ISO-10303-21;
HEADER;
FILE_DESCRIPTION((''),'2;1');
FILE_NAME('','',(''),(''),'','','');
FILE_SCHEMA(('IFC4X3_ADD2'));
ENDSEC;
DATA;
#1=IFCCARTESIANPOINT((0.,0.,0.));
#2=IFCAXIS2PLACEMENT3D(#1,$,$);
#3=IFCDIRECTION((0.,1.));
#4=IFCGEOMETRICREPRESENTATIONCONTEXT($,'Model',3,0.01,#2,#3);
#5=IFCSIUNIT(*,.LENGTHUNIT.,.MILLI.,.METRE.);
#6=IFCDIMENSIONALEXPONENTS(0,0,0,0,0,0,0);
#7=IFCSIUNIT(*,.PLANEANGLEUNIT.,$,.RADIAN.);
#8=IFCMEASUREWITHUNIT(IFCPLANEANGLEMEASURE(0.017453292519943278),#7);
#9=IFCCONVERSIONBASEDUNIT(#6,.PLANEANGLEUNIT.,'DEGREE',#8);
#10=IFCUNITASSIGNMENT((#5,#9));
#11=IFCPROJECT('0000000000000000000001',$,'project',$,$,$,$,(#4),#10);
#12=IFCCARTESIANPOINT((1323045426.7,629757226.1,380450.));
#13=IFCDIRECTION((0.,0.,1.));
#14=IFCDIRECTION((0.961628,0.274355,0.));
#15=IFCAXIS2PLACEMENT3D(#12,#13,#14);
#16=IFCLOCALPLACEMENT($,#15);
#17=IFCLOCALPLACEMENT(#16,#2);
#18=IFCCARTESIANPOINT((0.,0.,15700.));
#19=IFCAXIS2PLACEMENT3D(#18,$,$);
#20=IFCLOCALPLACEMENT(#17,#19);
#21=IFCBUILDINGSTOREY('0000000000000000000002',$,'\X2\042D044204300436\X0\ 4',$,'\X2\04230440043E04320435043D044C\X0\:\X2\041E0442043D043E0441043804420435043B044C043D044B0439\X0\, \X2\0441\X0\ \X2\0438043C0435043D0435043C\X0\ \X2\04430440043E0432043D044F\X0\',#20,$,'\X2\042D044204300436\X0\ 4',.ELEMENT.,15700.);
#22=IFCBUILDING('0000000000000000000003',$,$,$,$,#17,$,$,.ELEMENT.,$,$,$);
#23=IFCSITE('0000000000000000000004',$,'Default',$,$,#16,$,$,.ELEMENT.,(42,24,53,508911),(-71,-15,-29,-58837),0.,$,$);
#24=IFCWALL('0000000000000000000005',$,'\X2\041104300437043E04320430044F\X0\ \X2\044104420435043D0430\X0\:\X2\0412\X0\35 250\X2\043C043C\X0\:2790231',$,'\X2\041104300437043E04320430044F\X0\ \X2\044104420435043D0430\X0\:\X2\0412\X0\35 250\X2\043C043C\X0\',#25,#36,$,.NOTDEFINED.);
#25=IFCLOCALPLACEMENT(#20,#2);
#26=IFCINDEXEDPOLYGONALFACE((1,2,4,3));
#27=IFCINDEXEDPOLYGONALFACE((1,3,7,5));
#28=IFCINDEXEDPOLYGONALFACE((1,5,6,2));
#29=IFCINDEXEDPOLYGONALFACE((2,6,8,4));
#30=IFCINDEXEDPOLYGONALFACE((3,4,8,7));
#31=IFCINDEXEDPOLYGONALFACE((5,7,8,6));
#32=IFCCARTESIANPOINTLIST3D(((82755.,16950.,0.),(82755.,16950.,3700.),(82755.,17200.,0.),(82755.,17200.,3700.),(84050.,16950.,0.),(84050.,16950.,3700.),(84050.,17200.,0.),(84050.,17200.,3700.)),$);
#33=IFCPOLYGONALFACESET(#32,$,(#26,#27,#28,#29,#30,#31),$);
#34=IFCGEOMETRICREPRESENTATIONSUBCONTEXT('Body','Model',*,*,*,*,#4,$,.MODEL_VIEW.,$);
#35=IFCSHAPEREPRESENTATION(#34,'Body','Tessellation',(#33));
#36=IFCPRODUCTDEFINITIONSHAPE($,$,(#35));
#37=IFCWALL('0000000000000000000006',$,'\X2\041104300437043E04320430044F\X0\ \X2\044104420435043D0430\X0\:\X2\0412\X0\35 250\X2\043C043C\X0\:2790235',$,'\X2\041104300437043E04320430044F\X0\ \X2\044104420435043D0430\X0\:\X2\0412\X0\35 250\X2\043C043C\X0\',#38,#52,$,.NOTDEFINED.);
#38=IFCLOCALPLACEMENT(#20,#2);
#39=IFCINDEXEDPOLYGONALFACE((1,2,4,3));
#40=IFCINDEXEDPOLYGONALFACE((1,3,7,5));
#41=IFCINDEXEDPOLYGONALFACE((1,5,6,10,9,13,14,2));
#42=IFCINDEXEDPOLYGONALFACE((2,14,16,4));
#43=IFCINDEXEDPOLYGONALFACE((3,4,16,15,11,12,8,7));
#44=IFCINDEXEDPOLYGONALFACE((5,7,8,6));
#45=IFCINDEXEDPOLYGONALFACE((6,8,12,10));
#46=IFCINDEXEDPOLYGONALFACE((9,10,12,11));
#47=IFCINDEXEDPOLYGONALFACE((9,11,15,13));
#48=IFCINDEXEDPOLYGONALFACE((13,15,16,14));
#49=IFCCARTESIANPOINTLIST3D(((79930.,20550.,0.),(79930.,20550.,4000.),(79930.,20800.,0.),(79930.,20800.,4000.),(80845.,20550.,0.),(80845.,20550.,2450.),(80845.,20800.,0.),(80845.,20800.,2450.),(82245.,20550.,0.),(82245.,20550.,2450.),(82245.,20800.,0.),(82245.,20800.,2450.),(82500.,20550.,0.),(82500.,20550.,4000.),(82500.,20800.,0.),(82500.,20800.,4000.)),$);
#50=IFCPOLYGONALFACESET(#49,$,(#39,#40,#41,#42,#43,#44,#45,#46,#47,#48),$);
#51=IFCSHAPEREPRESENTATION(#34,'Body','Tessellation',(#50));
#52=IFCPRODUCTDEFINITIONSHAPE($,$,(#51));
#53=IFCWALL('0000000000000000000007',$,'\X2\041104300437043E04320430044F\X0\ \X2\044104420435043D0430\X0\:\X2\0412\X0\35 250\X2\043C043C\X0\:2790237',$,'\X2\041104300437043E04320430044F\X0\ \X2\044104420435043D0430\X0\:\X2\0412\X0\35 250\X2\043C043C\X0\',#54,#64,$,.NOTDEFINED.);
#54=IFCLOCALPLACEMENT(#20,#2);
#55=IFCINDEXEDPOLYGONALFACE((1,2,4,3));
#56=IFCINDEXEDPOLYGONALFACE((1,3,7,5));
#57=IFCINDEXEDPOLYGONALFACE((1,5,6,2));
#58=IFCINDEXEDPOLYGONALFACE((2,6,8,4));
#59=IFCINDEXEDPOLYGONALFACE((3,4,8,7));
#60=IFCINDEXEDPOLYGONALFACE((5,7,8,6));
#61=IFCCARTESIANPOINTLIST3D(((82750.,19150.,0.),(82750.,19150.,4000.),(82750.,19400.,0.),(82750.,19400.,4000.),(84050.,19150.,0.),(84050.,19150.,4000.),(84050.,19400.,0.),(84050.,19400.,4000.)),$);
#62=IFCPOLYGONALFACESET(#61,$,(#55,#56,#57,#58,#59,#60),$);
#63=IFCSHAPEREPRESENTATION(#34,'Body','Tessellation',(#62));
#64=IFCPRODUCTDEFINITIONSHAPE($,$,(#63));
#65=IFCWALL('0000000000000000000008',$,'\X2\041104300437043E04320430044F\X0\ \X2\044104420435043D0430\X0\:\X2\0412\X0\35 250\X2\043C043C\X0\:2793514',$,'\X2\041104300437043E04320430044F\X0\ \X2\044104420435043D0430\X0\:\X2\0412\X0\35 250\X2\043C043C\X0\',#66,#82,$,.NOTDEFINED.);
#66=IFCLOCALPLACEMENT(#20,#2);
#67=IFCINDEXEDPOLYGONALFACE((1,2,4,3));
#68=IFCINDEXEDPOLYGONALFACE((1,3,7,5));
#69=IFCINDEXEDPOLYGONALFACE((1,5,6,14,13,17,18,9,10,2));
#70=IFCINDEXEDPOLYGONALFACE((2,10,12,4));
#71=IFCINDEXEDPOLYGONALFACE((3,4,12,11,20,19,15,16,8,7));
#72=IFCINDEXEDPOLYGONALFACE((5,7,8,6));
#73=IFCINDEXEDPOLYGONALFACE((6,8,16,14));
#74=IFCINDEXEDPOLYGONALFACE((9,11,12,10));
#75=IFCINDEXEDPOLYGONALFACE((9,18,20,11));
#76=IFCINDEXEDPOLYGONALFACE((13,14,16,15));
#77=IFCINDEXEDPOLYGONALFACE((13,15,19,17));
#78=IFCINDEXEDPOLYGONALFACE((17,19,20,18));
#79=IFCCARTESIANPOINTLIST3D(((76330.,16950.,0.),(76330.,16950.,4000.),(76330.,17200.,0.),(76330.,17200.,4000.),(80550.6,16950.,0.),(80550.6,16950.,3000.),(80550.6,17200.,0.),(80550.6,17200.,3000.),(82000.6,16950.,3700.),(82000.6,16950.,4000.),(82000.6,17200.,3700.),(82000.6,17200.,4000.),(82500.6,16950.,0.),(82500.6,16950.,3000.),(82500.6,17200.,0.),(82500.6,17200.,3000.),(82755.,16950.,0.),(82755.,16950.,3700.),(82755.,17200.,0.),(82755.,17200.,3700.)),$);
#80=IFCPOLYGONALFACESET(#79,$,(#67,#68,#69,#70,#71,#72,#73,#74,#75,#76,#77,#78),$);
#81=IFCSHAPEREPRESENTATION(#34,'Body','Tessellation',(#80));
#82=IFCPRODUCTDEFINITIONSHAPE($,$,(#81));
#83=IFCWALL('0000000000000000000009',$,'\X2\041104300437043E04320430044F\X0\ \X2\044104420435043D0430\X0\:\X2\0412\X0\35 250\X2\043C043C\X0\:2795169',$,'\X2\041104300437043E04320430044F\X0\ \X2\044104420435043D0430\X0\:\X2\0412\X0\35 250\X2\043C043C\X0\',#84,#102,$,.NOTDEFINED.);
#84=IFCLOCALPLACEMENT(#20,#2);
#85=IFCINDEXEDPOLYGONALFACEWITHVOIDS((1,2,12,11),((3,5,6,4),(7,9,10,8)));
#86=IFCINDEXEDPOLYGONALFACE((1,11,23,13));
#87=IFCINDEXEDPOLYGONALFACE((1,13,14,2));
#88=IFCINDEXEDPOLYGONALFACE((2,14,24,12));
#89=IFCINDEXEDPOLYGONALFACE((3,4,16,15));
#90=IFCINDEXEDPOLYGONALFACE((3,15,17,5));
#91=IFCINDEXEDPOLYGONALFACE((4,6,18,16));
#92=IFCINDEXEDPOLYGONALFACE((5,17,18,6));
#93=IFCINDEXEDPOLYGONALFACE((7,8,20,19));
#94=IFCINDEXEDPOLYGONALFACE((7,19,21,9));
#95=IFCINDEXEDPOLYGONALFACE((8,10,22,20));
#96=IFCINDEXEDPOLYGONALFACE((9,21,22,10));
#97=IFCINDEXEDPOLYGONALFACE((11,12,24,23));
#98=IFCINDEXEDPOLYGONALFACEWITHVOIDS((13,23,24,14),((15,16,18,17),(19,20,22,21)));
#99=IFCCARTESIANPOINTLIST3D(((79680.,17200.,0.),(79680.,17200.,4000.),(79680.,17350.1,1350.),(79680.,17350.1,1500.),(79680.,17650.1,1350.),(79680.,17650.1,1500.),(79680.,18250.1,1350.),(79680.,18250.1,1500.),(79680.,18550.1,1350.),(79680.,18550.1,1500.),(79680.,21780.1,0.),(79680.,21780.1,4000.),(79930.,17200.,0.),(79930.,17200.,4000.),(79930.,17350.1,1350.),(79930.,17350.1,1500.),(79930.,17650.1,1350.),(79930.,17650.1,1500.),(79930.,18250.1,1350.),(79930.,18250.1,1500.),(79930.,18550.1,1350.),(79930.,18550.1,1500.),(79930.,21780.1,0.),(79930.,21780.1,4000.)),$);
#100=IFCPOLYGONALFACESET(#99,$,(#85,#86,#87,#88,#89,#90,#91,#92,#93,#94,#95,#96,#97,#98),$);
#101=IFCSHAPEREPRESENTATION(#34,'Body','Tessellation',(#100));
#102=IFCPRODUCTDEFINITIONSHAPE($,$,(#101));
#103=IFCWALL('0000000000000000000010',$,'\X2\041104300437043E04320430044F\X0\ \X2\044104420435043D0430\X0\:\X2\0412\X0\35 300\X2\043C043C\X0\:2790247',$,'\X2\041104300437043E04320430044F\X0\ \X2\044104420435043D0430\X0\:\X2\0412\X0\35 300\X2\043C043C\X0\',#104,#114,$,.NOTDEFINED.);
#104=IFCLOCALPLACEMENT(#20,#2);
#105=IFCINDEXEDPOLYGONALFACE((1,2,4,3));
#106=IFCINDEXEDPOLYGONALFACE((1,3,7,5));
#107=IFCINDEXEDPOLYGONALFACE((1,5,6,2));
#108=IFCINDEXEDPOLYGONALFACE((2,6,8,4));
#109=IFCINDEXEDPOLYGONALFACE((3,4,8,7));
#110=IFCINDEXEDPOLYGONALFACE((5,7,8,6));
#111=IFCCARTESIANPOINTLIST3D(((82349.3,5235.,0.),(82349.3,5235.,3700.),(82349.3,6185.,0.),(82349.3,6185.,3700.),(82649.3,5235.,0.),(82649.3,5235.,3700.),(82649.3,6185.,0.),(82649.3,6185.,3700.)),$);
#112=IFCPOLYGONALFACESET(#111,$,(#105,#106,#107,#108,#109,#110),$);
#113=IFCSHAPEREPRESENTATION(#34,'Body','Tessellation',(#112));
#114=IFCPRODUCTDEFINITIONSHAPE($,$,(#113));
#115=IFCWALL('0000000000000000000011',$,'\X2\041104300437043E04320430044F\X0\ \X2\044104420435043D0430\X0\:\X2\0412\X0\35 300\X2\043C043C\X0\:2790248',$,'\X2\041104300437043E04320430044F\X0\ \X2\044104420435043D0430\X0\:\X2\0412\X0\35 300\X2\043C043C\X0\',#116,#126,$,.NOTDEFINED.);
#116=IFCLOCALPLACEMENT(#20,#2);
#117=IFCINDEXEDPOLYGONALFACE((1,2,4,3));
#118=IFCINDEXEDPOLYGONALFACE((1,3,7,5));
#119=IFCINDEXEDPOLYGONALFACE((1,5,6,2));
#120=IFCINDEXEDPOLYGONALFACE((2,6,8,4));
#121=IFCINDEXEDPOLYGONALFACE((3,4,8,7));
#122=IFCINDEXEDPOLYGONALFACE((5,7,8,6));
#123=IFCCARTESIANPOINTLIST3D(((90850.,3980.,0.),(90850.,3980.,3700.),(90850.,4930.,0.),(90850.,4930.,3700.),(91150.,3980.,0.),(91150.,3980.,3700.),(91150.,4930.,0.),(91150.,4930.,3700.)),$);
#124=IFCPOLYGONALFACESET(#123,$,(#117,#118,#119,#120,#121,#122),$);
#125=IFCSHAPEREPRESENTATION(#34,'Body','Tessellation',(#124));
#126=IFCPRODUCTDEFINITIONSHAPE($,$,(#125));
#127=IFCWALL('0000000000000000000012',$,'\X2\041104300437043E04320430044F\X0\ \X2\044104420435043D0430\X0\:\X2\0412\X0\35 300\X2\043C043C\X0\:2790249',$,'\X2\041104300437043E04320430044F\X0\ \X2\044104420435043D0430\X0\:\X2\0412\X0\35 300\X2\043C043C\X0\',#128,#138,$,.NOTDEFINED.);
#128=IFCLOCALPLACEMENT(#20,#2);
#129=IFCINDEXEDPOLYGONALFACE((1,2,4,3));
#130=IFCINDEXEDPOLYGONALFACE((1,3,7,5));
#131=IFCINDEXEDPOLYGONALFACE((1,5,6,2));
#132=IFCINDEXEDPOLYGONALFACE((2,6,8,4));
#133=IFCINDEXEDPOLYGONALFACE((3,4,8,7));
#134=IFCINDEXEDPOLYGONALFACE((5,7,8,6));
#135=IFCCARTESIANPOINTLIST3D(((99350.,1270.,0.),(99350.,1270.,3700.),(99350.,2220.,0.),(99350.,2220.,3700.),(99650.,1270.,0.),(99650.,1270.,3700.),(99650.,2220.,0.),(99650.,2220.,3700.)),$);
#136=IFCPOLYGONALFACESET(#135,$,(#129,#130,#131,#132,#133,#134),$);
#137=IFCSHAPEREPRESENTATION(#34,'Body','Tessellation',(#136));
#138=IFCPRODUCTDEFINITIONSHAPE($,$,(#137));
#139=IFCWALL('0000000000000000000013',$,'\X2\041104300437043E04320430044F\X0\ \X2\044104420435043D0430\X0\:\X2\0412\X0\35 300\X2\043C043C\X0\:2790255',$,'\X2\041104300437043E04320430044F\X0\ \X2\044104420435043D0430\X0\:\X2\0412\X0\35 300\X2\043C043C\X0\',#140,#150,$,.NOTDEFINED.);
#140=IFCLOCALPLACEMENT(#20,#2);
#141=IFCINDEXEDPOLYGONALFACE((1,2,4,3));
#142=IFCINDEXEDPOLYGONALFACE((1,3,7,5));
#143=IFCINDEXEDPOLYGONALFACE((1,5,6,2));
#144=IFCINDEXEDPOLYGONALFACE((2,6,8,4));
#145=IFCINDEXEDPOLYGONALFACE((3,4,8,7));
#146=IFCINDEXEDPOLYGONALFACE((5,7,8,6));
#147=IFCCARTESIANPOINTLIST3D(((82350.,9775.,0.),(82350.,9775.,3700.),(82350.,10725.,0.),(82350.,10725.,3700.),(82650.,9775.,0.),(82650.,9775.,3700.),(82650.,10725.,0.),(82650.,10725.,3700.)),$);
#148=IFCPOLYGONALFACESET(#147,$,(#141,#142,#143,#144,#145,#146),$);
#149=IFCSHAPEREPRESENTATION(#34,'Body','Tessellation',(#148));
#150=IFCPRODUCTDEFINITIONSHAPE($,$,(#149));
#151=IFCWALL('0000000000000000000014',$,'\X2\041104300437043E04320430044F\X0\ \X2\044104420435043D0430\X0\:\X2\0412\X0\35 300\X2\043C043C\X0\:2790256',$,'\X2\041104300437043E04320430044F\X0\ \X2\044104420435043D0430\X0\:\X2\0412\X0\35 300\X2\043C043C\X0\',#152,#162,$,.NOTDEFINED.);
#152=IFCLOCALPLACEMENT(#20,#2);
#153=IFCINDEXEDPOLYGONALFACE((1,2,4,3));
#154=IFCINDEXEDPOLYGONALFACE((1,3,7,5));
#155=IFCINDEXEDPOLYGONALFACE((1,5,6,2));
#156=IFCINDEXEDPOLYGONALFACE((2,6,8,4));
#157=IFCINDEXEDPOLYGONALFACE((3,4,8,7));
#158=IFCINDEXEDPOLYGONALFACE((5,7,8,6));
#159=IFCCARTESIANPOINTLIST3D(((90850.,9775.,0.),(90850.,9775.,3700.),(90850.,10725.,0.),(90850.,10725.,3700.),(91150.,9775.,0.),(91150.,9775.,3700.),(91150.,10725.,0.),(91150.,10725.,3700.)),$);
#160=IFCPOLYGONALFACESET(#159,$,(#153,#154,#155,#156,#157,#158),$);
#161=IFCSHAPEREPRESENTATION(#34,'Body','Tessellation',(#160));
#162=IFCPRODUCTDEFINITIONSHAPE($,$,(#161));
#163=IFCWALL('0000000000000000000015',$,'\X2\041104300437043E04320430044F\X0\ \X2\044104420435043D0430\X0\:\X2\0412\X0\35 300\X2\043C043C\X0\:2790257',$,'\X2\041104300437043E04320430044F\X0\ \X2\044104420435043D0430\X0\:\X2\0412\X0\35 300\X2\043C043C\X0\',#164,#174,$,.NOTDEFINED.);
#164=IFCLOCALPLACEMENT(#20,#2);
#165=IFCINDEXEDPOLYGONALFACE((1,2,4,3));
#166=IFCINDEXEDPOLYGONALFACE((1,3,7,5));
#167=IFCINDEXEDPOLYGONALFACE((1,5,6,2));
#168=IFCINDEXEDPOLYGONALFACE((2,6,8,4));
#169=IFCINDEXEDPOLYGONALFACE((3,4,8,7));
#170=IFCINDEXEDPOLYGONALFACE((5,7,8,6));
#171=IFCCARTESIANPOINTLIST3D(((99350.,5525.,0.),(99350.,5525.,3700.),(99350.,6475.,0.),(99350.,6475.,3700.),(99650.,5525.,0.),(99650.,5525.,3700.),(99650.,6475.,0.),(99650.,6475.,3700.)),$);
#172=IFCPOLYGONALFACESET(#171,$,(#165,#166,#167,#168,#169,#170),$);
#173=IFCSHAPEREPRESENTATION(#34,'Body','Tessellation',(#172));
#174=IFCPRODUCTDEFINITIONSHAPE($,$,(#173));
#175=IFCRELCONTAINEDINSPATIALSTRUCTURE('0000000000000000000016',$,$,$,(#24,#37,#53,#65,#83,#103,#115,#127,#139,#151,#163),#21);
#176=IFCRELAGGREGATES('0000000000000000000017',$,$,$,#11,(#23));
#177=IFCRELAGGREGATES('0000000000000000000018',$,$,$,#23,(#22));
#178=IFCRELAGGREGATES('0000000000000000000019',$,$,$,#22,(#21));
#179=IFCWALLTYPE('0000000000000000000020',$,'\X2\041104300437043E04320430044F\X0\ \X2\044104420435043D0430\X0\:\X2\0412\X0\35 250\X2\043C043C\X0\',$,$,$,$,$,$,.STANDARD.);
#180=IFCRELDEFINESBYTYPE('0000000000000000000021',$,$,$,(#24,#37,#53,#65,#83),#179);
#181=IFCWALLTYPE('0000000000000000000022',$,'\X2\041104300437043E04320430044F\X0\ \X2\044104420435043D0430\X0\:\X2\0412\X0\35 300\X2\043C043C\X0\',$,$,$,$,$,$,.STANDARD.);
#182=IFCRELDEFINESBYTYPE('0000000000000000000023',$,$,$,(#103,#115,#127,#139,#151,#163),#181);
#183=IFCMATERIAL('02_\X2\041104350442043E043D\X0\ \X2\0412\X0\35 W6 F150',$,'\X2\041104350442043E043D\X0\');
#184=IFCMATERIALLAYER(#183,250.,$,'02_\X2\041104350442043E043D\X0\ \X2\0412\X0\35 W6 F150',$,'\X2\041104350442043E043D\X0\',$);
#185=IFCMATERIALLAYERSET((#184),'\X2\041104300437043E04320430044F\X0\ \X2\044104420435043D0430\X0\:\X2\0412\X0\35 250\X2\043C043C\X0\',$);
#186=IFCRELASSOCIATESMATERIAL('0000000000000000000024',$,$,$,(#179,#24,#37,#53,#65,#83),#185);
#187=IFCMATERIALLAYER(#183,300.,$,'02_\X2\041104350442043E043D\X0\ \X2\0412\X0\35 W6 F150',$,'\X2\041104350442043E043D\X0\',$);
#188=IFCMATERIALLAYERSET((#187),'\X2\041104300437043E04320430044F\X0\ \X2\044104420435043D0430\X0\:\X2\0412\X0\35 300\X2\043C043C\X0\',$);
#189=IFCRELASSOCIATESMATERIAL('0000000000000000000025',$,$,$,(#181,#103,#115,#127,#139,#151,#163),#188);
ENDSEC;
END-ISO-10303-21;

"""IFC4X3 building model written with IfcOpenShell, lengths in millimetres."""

from ifc_helpers import new_model, entity, si_unit, converted_unit, direction, frame, frame_2d, origin, origin_2d_with_axis, place, context, subcontext, project, spatial, rectangle, extrude, clip, halfspace, material, layer, layer_set, type_object, element, save


model = new_model("IFC4X3")

# Units and contexts
model_context = context("Model", 3, precision=0.01, world=origin(), true_north=direction((0.0, 1.0)))
body_context = subcontext(model_context, "Body", "Model", "MODEL_VIEW")
ifc_project = project(units=[si_unit("LENGTHUNIT", "METRE", prefix="MILLI"), converted_unit("PLANEANGLEUNIT", "DEGREE", entity("IfcPlaneAngleMeasure", 0.017453292519943278), si_unit("PLANEANGLEUNIT", "RADIAN"), dimensions=[0, 0, 0, 0, 0, 0, 0])], contexts=[model_context])

# Site, building, storey
site_placement = place(None, frame((1323045426.7, 629757226.1, 380450.0), z_axis=(0.0, 0.0, 1.0), x_axis=(0.961628, 0.274355, 0.0)))
site = spatial("IfcSite", under=ifc_project, at=site_placement, Name="Default", CompositionType="ELEMENT", RefLatitude=(42, 24, 53, 508911), RefLongitude=(-71, -15, -29, -58837), RefElevation=0.0)
building_placement = place(site_placement, origin())
building = spatial("IfcBuilding", under=site, at=building_placement, CompositionType="ELEMENT")
storey_placement = place(building_placement, frame((0.0, 0.0, 15700.0)))
storey = spatial("IfcBuildingStorey", under=building, at=storey_placement, Name="Этаж 4", ObjectType="Уровень:Относительный, с именем уровня", LongName="Этаж 4", CompositionType="ELEMENT", Elevation=15700.0)

# Wall
ifc_material = material(Name="02_Бетон В35 W6 F150", Category="Бетон")
ifc_layer_1 = layer(ifc_material, 250.0, Name="02_Бетон В35 W6 F150", Category="Бетон")
ifc_layer_set_1 = layer_set([ifc_layer_1], Name="Базовая стена:В35 250мм")
wall_type_1 = type_object("IfcWallType", Name="Базовая стена:В35 250мм", PredefinedType="STANDARD", material=ifc_layer_set_1)
wall_1_placement = place(storey_placement, frame((84050.0, 17075.0, 0.0), z_axis=(0.0, 0.0, 1.0), x_axis=(-1.0, 0.0, 0.0)))
element("IfcWall", 1, at=wall_1_placement, inside=storey, type_object=wall_type_1, material=ifc_layer_set_1, Name="Базовая стена:В35 250мм:2790231", ObjectType="Базовая стена:В35 250мм", PredefinedType="NOTDEFINED", context=body_context, shape_type="SweptSolid", body=[
    extrude(rectangle(XDim=1295.0, YDim=250.0, at=frame_2d((647.5, 0.0), x_axis=(-1.0, 0.0))), origin(), (0.0, 0.0, 1.0), 3700.0),
])

# Wall, opening
wall_2_placement = place(storey_placement, frame((79930.0, 20675.0, 0.0)))
wall_2 = element("IfcWall", 2, at=wall_2_placement, inside=storey, type_object=wall_type_1, material=ifc_layer_set_1, Name="Базовая стена:В35 250мм:2790235", ObjectType="Базовая стена:В35 250мм", PredefinedType="NOTDEFINED", context=body_context, shape_type="SweptSolid", body=[
    extrude(rectangle(XDim=2570.0, YDim=250.0, at=frame_2d((1285.0, 0.0), x_axis=(-1.0, 0.0))), origin(), (0.0, 0.0, 1.0), 4000.0),
])
opening_1_placement = place(wall_2_placement, frame((-79930.0, -20675.0, 0.0)))
element("IfcOpeningElement", 3, at=opening_1_placement, cuts=wall_2, PredefinedType="OPENING", context=body_context, shape_type="SweptSolid", body=[
    extrude(rectangle(XDim=2450.0, YDim=1400.0, at=frame_2d((0.0, 0.0), x_axis=(0.0, 1.0))), frame((81545.0, 19276.0, 1225.0), z_axis=(0.0, 1.0, 0.0), x_axis=(1.0, 0.0, 0.0)), (0.0, 0.0, 1.0), 3048.0),
])

# Wall
wall_3_placement = place(storey_placement, frame((82750.0, 19275.0, 0.0)))
element("IfcWall", 4, at=wall_3_placement, inside=storey, type_object=wall_type_1, material=ifc_layer_set_1, Name="Базовая стена:В35 250мм:2790237", ObjectType="Базовая стена:В35 250мм", PredefinedType="NOTDEFINED", context=body_context, shape_type="SweptSolid", body=[
    extrude(rectangle(XDim=1300.0, YDim=250.0, at=frame_2d((650.0, 0.0), x_axis=(-1.0, 0.0))), origin(), (0.0, 0.0, 1.0), 4000.0),
])

# Walls, openings
wall_4_placement = place(storey_placement, frame((82755.0, 17075.0, 0.0), z_axis=(0.0, 0.0, 1.0), x_axis=(-1.0, 0.0, 0.0)))
wall_4 = element("IfcWall", 5, at=wall_4_placement, inside=storey, type_object=wall_type_1, material=ifc_layer_set_1, Name="Базовая стена:В35 250мм:2793514", ObjectType="Базовая стена:В35 250мм", PredefinedType="NOTDEFINED", context=body_context, shape_type="Clipping", body=[
    clip(extrude(rectangle(XDim=6425.0, YDim=250.0, at=frame_2d((3212.5, 0.0), x_axis=(-1.0, 0.0))), origin(), (0.0, 0.0, 1.0), 4000.0), halfspace(frame((754.4, -125.0, 4000.0), z_axis=(0.0, 0.0, 1.0), x_axis=(0.0, 1.0, 0.0)), False)),
])
opening_2_placement = place(wall_4_placement, origin())
element("IfcOpeningElement", 6, at=opening_2_placement, cuts=wall_4, PredefinedType="OPENING", context=body_context, shape_type="SweptSolid", body=[
    extrude(rectangle(XDim=300.0, YDim=754.4, at=frame_2d((0.0, 0.0), x_axis=(0.0, 1.0))), frame((377.2, 125.0, 3850.0), z_axis=(0.0, -1.0, 0.0), x_axis=(-1.0, 0.0, 0.0)), (0.0, 0.0, 1.0), 250.0),
])
opening_3_placement = place(wall_4_placement, frame((82755.0, 17075.0, 0.0), z_axis=(0.0, 0.0, 1.0), x_axis=(-1.0, 0.0, 0.0)))
element("IfcOpeningElement", 7, at=opening_3_placement, cuts=wall_4, PredefinedType="OPENING", context=body_context, shape_type="SweptSolid", body=[
    extrude(rectangle(XDim=3000.0, YDim=1950.0, at=origin_2d_with_axis()), frame((81525.6, 18724.0, 1500.0), z_axis=(0.0, -1.0, 0.0), x_axis=(0.0, 0.0, -1.0)), (0.0, 0.0, 1.0), 3048.0),
])
wall_5_placement = place(storey_placement, frame((79805.0, 21780.1, 0.0), z_axis=(0.0, 0.0, 1.0), x_axis=(0.0, -1.0, 0.0)))
wall_5 = element("IfcWall", 8, at=wall_5_placement, inside=storey, type_object=wall_type_1, material=ifc_layer_set_1, Name="Базовая стена:В35 250мм:2795169", ObjectType="Базовая стена:В35 250мм", PredefinedType="NOTDEFINED", context=body_context, shape_type="SweptSolid", body=[
    extrude(rectangle(XDim=4580.1, YDim=250.0, at=frame_2d((2290.1, 0.0), x_axis=(-1.0, 0.0))), origin(), (0.0, 0.0, 1.0), 4000.0),
])
opening_4_placement = place(wall_5_placement, frame((21780.1, -79805.0, 1350.0), z_axis=(0.0, 0.0, 1.0), x_axis=(0.0, 1.0, 0.0)))
element("IfcOpeningElement", 9, at=opening_4_placement, cuts=wall_5, PredefinedType="OPENING", context=body_context, shape_type="SweptSolid", body=[
    extrude(rectangle(XDim=150.0, YDim=300.0, at=frame_2d((0.0, 0.0), x_axis=(0.0, 1.0))), frame((78156.0, 18400.1, 75.0), z_axis=(1.0, 0.0, 0.0), x_axis=(0.0, -1.0, 0.0)), (0.0, 0.0, 1.0), 3048.0),
])
opening_5_placement = place(wall_5_placement, frame((21780.1, -79805.0, 1350.0), z_axis=(0.0, 0.0, 1.0), x_axis=(0.0, 1.0, 0.0)))
element("IfcOpeningElement", 10, at=opening_5_placement, cuts=wall_5, PredefinedType="OPENING", context=body_context, shape_type="SweptSolid", body=[
    extrude(rectangle(XDim=150.0, YDim=300.0, at=frame_2d((0.0, 0.0), x_axis=(0.0, 1.0))), frame((78156.0, 17500.1, 75.0), z_axis=(1.0, 0.0, 0.0), x_axis=(0.0, -1.0, 0.0)), (0.0, 0.0, 1.0), 3048.0),
])

# Walls
ifc_layer_2 = layer(ifc_material, 300.0, Name="02_Бетон В35 W6 F150", Category="Бетон")
ifc_layer_set_2 = layer_set([ifc_layer_2], Name="Базовая стена:В35 300мм")
wall_type_2 = type_object("IfcWallType", Name="Базовая стена:В35 300мм", PredefinedType="STANDARD", material=ifc_layer_set_2)
wall_6_placement = place(storey_placement, frame((82499.3, 5235.0, 0.0), z_axis=(0.0, 0.0, 1.0), x_axis=(0.0, 1.0, 0.0)))
element("IfcWall", 11, at=wall_6_placement, inside=storey, type_object=wall_type_2, material=ifc_layer_set_2, Name="Базовая стена:В35 300мм:2790247", ObjectType="Базовая стена:В35 300мм", PredefinedType="NOTDEFINED", context=body_context, shape_type="SweptSolid", body=[
    extrude(rectangle(XDim=950.0, YDim=300.0, at=frame_2d((475.0, 0.0), x_axis=(-1.0, 0.0))), origin(), (0.0, 0.0, 1.0), 3700.0),
])
wall_7_placement = place(storey_placement, frame((91000.0, 3980.0, 0.0), z_axis=(0.0, 0.0, 1.0), x_axis=(0.0, 1.0, 0.0)))
element("IfcWall", 12, at=wall_7_placement, inside=storey, type_object=wall_type_2, material=ifc_layer_set_2, Name="Базовая стена:В35 300мм:2790248", ObjectType="Базовая стена:В35 300мм", PredefinedType="NOTDEFINED", context=body_context, shape_type="SweptSolid", body=[
    extrude(rectangle(XDim=950.0, YDim=300.0, at=frame_2d((475.0, 0.0), x_axis=(-1.0, 0.0))), origin(), (0.0, 0.0, 1.0), 3700.0),
])
wall_8_placement = place(storey_placement, frame((99500.0, 1270.0, 0.0), z_axis=(0.0, 0.0, 1.0), x_axis=(0.0, 1.0, 0.0)))
element("IfcWall", 13, at=wall_8_placement, inside=storey, type_object=wall_type_2, material=ifc_layer_set_2, Name="Базовая стена:В35 300мм:2790249", ObjectType="Базовая стена:В35 300мм", PredefinedType="NOTDEFINED", context=body_context, shape_type="SweptSolid", body=[
    extrude(rectangle(XDim=950.0, YDim=300.0, at=frame_2d((475.0, 0.0), x_axis=(-1.0, 0.0))), origin(), (0.0, 0.0, 1.0), 3700.0),
])
wall_9_placement = place(storey_placement, frame((82500.0, 9775.0, 0.0), z_axis=(0.0, 0.0, 1.0), x_axis=(0.0, 1.0, 0.0)))
element("IfcWall", 14, at=wall_9_placement, inside=storey, type_object=wall_type_2, material=ifc_layer_set_2, Name="Базовая стена:В35 300мм:2790255", ObjectType="Базовая стена:В35 300мм", PredefinedType="NOTDEFINED", context=body_context, shape_type="SweptSolid", body=[
    extrude(rectangle(XDim=950.0, YDim=300.0, at=frame_2d((475.0, 0.0), x_axis=(-1.0, 0.0))), origin(), (0.0, 0.0, 1.0), 3700.0),
])
for number, where, z_axis, x_axis, name in (
    (15, (91000.0, 9775.0, 0.0), (0.0, 0.0, 1.0), (0.0, 1.0, 0.0), "Базовая стена:В35 300мм:2790256"),
    (16, (99500.0, 5525.0, 0.0), (0.0, 0.0, 1.0), (0.0, 1.0, 0.0), "Базовая стена:В35 300мм:2790257"),
):
    element("IfcWall", number, at=place(storey_placement, frame(where, z_axis=z_axis, x_axis=x_axis)), inside=storey, type_object=wall_type_2, material=ifc_layer_set_2, Name=name, ObjectType="Базовая стена:В35 300мм", PredefinedType="NOTDEFINED", context=body_context, shape_type="SweptSolid", body=[
        extrude(rectangle(XDim=950.0, YDim=300.0, at=frame_2d((475.0, 0.0), x_axis=(-1.0, 0.0))), origin(), (0.0, 0.0, 1.0), 3700.0),
    ])

save(model, "model.ifc")
